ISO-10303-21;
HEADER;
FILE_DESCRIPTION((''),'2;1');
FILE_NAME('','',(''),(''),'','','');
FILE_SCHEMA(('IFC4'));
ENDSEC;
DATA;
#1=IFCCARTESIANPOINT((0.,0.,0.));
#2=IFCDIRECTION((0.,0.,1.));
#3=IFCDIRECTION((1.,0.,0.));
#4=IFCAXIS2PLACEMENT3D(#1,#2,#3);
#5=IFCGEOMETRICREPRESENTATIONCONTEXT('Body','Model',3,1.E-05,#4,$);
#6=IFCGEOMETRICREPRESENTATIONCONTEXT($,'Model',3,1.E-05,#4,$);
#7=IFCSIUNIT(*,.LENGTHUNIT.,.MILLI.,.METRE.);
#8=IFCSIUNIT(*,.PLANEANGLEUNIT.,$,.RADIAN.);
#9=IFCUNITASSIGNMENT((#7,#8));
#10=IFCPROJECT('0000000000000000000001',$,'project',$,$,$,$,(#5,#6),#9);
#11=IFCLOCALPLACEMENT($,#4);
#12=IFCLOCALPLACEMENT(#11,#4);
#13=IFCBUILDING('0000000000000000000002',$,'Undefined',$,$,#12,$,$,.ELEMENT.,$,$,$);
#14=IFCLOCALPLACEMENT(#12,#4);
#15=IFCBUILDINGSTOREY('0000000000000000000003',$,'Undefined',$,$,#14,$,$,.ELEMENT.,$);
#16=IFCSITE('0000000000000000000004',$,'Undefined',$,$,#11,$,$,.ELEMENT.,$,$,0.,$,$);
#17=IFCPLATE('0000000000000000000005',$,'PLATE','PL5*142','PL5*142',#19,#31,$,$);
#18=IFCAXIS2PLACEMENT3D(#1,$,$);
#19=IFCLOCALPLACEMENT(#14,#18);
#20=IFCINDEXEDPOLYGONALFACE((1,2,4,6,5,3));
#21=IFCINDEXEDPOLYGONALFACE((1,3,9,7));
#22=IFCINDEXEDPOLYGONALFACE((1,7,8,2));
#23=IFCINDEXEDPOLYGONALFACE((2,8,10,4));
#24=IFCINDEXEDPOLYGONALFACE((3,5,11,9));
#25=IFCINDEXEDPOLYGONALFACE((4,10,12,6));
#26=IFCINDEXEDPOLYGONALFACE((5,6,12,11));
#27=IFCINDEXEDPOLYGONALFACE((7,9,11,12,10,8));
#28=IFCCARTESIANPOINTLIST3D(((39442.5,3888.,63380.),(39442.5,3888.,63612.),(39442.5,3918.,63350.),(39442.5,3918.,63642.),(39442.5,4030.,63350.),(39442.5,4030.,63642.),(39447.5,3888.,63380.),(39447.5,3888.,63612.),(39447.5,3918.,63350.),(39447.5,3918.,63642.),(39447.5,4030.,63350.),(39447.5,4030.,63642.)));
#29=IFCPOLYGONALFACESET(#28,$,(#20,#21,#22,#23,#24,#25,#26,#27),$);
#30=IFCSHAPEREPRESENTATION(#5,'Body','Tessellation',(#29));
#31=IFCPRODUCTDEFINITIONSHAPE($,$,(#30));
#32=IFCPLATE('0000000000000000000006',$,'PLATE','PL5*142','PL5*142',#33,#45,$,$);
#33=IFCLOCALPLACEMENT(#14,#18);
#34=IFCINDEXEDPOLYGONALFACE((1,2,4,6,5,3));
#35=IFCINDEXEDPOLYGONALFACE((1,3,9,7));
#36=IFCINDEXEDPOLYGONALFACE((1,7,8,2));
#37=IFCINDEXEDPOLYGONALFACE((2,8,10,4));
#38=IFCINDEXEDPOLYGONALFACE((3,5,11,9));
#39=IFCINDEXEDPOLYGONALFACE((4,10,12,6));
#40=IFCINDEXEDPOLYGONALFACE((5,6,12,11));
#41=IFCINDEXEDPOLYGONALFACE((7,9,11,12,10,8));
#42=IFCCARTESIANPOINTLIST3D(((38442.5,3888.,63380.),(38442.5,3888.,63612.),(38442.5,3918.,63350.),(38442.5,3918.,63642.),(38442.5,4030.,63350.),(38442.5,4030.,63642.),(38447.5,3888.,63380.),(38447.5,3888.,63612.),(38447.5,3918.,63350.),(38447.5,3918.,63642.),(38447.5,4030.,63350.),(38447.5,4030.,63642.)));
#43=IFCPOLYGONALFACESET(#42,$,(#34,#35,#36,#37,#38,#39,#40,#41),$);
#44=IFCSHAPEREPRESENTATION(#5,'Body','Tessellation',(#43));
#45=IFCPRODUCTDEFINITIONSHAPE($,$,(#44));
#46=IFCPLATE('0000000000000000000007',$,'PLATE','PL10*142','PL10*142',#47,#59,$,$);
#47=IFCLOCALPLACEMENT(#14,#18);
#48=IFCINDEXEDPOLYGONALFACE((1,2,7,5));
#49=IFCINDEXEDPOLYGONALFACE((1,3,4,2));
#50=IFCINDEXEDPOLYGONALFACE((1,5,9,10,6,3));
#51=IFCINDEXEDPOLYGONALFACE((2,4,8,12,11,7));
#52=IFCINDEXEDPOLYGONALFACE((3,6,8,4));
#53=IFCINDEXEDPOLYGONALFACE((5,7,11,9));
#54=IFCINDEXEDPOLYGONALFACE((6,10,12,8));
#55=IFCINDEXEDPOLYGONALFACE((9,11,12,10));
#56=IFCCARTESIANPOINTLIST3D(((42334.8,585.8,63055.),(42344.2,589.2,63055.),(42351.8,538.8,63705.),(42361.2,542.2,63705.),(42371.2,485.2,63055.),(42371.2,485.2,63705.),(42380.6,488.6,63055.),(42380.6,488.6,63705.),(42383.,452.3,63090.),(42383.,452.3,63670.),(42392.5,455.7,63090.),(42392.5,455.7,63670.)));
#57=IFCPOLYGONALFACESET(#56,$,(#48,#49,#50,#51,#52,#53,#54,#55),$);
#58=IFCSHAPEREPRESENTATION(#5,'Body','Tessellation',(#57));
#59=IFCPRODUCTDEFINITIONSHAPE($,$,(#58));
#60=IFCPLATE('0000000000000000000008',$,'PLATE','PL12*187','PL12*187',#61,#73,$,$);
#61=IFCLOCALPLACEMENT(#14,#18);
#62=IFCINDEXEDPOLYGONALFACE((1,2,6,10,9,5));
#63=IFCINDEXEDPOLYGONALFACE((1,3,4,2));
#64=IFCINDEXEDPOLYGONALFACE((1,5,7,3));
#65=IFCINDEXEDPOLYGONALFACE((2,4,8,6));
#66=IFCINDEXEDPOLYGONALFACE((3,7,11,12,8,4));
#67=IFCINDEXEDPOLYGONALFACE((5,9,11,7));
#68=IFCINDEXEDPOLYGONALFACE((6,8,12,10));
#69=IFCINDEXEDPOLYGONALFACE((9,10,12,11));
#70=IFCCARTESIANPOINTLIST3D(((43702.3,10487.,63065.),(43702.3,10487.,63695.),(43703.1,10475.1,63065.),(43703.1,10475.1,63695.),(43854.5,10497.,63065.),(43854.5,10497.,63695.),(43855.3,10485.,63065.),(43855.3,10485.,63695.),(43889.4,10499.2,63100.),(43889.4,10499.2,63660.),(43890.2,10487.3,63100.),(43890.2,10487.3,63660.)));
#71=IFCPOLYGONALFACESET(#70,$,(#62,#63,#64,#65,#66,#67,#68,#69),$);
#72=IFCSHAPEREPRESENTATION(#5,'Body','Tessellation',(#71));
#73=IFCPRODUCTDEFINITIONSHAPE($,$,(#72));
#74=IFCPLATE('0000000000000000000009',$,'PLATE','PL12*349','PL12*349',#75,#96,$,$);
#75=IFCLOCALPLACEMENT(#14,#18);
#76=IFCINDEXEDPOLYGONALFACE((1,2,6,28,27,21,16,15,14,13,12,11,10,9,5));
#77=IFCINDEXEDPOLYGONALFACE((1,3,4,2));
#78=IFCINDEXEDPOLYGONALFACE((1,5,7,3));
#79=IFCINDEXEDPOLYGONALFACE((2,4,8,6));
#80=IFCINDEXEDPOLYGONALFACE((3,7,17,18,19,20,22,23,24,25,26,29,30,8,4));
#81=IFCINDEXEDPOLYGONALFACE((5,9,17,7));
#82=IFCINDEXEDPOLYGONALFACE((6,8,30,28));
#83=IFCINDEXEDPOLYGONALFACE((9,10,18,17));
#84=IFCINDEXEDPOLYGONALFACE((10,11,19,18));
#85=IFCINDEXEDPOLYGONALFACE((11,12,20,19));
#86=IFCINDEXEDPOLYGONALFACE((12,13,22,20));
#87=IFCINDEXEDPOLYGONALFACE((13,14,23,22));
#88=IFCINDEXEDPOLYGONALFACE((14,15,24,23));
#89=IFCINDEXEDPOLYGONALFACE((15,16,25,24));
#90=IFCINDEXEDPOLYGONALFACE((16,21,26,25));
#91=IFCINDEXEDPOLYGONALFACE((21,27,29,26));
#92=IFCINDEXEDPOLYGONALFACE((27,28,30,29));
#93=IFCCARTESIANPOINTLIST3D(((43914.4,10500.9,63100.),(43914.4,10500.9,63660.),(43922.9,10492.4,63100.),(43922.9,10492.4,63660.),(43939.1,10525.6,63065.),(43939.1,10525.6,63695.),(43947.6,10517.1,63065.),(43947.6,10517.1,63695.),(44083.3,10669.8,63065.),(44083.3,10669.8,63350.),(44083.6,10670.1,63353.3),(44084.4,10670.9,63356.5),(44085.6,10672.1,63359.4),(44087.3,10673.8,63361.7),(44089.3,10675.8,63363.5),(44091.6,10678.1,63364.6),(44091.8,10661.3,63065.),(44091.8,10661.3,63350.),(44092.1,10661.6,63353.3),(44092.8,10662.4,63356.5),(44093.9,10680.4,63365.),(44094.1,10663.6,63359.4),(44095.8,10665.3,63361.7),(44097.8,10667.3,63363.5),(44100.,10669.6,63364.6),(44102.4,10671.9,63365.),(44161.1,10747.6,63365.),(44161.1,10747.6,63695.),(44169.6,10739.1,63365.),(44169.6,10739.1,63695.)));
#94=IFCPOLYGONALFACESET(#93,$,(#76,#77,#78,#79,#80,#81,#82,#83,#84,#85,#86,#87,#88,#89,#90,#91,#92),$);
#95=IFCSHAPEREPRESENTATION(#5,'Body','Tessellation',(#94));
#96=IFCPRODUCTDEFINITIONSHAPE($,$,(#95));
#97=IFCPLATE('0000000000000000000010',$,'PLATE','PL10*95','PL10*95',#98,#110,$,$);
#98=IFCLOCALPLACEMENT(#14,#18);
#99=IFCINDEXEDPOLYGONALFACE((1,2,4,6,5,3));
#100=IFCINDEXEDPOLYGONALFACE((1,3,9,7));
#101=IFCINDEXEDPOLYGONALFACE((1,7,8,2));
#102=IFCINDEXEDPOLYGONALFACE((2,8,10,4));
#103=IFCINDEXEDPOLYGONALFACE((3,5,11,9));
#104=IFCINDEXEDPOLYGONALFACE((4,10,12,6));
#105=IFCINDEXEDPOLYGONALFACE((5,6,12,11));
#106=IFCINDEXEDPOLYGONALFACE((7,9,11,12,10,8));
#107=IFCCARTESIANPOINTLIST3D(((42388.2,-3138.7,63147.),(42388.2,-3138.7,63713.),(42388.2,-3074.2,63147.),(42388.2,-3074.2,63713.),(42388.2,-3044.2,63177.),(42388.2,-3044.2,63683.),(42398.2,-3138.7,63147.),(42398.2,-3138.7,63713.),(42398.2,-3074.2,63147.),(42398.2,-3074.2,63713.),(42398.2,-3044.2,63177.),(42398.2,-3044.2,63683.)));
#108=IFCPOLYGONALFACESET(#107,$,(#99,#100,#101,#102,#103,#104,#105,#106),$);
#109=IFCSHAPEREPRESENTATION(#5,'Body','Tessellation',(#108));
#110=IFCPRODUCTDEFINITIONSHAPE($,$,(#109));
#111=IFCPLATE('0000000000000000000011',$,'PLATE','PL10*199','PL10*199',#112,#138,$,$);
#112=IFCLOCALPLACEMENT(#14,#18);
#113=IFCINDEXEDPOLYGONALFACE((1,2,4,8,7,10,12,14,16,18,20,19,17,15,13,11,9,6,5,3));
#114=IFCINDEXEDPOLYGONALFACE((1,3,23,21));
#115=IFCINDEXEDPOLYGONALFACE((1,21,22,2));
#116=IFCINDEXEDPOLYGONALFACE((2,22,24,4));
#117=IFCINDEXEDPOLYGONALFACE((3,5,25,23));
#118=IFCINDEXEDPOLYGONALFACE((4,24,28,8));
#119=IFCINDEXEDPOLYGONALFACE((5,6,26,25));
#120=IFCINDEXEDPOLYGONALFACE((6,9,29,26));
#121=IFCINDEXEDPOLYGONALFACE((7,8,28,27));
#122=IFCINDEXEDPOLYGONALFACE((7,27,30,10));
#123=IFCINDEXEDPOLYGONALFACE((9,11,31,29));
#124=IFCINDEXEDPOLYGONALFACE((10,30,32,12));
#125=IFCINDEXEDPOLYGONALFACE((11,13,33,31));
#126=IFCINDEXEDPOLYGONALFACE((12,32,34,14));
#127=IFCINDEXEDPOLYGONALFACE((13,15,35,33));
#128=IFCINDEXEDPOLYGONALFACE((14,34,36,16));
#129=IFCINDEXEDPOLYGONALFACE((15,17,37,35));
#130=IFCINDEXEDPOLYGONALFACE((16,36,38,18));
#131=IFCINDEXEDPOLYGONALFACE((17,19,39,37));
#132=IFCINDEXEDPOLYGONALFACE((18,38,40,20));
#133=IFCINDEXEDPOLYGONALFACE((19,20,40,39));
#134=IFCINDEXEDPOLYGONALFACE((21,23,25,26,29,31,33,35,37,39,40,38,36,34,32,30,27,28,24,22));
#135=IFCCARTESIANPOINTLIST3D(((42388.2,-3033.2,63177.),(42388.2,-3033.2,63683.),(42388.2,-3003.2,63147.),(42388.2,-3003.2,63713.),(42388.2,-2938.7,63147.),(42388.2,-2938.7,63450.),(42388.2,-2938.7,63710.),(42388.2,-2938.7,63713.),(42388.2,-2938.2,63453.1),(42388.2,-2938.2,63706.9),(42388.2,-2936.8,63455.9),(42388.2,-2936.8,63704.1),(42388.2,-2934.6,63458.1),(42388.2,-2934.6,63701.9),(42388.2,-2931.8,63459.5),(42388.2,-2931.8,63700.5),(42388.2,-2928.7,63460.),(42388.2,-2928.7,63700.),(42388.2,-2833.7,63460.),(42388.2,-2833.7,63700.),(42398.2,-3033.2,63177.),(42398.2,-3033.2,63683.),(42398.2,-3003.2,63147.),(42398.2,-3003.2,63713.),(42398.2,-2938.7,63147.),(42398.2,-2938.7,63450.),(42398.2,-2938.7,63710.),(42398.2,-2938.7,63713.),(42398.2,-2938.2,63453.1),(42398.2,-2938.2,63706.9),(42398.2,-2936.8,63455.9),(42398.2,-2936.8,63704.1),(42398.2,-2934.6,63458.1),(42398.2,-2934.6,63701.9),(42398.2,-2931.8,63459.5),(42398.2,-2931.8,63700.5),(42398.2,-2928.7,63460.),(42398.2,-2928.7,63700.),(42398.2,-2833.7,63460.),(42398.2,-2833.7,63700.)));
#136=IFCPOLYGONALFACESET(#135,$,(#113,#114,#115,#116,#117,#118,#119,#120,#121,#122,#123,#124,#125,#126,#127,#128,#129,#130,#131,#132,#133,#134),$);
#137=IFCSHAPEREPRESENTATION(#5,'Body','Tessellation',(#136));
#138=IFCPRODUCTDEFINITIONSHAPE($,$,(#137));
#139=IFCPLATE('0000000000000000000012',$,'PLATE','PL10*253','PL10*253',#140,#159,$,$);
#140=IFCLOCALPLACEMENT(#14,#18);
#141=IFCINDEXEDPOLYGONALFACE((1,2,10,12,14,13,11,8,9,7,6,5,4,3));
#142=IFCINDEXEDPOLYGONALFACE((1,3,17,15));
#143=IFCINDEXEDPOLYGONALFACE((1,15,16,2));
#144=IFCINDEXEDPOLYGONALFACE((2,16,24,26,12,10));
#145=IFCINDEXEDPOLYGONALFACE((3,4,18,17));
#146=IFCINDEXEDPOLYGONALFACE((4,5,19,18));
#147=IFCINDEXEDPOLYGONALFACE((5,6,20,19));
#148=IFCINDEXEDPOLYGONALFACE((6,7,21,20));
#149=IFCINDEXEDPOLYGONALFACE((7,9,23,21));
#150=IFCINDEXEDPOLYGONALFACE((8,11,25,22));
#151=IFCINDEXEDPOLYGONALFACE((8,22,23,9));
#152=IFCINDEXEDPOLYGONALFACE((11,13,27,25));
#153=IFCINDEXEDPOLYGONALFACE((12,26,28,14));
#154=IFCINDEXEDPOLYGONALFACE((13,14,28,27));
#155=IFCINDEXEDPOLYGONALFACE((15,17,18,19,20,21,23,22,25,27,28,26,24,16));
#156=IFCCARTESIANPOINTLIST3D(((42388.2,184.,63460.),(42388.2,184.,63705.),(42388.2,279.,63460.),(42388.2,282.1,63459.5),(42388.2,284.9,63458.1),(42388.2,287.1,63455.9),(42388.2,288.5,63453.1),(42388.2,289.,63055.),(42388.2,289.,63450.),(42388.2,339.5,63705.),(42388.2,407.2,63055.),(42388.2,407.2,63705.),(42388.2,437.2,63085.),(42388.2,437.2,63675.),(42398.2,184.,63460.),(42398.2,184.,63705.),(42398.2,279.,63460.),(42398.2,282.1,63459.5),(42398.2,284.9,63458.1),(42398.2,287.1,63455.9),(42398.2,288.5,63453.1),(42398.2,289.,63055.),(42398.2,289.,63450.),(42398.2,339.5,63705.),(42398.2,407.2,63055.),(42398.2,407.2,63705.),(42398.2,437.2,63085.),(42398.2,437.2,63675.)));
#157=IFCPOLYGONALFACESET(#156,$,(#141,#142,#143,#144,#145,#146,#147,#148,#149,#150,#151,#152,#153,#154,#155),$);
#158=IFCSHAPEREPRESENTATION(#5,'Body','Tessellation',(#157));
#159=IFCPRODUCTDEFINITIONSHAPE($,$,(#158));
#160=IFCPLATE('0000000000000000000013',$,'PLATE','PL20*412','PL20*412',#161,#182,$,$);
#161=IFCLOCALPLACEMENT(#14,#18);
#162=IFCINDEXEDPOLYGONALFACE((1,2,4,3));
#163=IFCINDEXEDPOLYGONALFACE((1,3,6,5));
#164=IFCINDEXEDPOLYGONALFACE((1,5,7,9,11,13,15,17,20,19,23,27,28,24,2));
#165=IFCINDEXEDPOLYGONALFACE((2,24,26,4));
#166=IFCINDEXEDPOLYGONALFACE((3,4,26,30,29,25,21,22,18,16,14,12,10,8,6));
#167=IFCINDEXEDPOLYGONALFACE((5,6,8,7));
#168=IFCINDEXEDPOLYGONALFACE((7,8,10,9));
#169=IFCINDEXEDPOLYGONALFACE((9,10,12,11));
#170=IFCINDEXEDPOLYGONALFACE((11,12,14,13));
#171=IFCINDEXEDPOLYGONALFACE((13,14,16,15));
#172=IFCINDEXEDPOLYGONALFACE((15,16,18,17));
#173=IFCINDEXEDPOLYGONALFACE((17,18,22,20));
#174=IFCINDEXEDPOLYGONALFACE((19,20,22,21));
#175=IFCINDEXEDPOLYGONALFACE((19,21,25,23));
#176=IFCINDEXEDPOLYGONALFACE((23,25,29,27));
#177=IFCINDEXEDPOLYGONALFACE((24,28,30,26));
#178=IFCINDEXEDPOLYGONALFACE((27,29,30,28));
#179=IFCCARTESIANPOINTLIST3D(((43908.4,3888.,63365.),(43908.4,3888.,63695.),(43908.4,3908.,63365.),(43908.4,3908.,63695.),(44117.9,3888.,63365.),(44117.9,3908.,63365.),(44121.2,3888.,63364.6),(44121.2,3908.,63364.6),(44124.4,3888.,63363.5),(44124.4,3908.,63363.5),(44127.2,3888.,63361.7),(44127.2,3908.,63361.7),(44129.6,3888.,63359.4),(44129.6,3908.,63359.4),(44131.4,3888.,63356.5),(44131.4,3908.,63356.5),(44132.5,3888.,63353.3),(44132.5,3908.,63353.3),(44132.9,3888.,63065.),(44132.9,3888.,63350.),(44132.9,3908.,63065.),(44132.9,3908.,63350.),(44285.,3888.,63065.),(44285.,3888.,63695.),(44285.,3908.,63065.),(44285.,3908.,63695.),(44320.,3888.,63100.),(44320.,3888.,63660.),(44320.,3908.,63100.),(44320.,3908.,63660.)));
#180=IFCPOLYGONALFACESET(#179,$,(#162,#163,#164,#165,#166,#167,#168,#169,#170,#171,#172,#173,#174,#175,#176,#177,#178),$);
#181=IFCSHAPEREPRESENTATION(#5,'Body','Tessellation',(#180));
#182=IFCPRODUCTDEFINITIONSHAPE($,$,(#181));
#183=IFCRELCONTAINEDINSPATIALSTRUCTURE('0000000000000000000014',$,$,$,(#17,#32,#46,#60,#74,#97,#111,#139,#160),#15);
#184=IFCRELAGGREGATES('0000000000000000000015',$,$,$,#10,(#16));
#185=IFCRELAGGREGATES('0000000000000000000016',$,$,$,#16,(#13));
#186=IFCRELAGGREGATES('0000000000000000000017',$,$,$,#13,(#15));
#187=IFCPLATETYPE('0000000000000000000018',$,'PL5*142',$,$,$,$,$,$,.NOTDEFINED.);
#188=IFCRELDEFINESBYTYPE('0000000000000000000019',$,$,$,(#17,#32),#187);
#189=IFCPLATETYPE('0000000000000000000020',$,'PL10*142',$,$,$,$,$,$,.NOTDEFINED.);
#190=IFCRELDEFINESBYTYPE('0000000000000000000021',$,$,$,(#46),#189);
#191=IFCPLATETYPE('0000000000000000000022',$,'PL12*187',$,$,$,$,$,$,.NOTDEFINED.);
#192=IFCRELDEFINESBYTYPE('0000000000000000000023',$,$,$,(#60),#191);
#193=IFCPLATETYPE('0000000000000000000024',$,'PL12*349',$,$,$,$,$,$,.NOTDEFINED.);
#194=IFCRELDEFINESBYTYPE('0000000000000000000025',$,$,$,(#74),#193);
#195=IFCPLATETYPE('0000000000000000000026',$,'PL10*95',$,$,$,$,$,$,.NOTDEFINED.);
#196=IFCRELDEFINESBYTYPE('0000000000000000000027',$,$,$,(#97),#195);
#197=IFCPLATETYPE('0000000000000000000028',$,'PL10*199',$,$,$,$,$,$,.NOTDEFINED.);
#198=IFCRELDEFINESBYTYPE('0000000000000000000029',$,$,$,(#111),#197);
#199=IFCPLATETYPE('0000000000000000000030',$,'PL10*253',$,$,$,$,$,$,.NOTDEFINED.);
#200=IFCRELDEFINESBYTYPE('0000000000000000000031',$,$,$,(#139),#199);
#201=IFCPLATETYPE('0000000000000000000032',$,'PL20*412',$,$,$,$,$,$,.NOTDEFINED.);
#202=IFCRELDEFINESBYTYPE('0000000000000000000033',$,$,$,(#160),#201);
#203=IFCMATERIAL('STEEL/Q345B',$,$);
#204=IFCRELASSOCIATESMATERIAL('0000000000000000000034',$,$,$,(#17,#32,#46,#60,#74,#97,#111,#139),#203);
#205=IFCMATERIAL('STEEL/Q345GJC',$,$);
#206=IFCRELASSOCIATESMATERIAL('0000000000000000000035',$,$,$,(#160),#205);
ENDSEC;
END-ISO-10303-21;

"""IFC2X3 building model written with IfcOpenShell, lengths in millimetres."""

from ifc_helpers import new_model, si_unit, frame, origin_with_axes, place, context, project, spatial, polyline, outline, extrude, material, type_object, element, save


model = new_model("IFC2X3")

# Units and contexts
model_context_1 = context("Model", 3, precision=1e-05, world=origin_with_axes(), identifier="Body")
model_context_2 = context("Model", 3, precision=1e-05, world=origin_with_axes())
ifc_project = project(units=[si_unit("LENGTHUNIT", "METRE", prefix="MILLI"), si_unit("PLANEANGLEUNIT", "RADIAN")], contexts=[model_context_1, model_context_2])

# Site, building, storey
site_placement = place(None, origin_with_axes())
site = spatial("IfcSite", under=ifc_project, at=site_placement, Name="Undefined", CompositionType="ELEMENT", RefElevation=0.0)
building_placement = place(site_placement, origin_with_axes())
building = spatial("IfcBuilding", under=site, at=building_placement, Name="Undefined", CompositionType="ELEMENT")
storey_placement = place(building_placement, origin_with_axes())
storey = spatial("IfcBuildingStorey", under=building, at=storey_placement, Name="Undefined", CompositionType="ELEMENT")

# Shared definitions
ifc_material_1 = material(Name="STEEL/Q345B")
ifc_material_2 = material(Name="STEEL/Q345GJC")

# Plates
plate_type_1 = type_object("IfcPlateType", Name="PL5*142", PredefinedType="NOTDEFINED")
for number, where, z_axis, x_axis, name in (
    (1, (39445.0, 4030.0, 63642.0), (1.0, 0.0, 0.0), (0.0, -1.0, 0.0), "PLATE"),
    (2, (38445.0, 4030.0, 63642.0), (1.0, 0.0, 0.0), (0.0, -1.0, 0.0), "PLATE"),
):
    element("IfcPlate", number, at=place(storey_placement, frame(where, z_axis=z_axis, x_axis=x_axis)), inside=storey, type_object=plate_type_1, material=ifc_material_1, Name=name, Description="PL5*142", ObjectType="PL5*142", context=model_context_1, shape_type="SweptSolid", body=[
        extrude(outline(polyline([(0.0, 0.0), (112.0, 0.0), (142.0, 30.0), (142.0, 262.0), (112.0, 292.0), (0.0, 292.0), (0.0, 0.0)])), frame((0.0, 0.0, -2.5), z_axis=(0.0, 0.0, 1.0), x_axis=(1.0, 0.0, 0.0)), (0.0, 0.0, 1.0), 5.0),
    ])
plate_type_2 = type_object("IfcPlateType", Name="PL10*142", PredefinedType="NOTDEFINED")
plate_1_placement = place(storey_placement, frame((42387.8, 454.0, 63705.0), z_axis=(-0.940467, -0.339884, 0.0), x_axis=(-0.339884, 0.940467, 0.0)))
element("IfcPlate", 3, at=plate_1_placement, inside=storey, type_object=plate_type_2, material=ifc_material_1, Name="PLATE", Description="PL10*142", ObjectType="PL10*142", context=model_context_1, shape_type="SweptSolid", body=[
    extrude(outline(polyline([(0.0, 35.0), (35.0, 0.0), (92.0, 0.0), (142.0, 650.0), (35.0, 650.0), (0.0, 615.0), (0.0, 35.0)])), frame((0.0, 0.0, -5.0), z_axis=(0.0, 0.0, 1.0), x_axis=(1.0, 0.0, 0.0)), (0.0, 0.0, 1.0), 10.0),
])
plate_type_3 = type_object("IfcPlateType", Name="PL12*187", PredefinedType="NOTDEFINED")
plate_2_placement = place(storey_placement, frame((43889.8, 10493.3, 63065.0), z_axis=(-0.065184, 0.997873, 0.0), x_axis=(-0.997873, -0.065183, 0.0)))
element("IfcPlate", 4, at=plate_2_placement, inside=storey, type_object=plate_type_3, material=ifc_material_1, Name="PLATE", Description="PL12*187", ObjectType="PL12*187", context=model_context_1, shape_type="SweptSolid", body=[
    extrude(outline(polyline([(0.0, 35.0), (35.0, 0.0), (187.5, 0.0), (187.5, 630.0), (35.0, 630.0), (0.0, 595.0), (0.0, 35.0)])), frame((0.0, 0.0, -6.0), z_axis=(0.0, 0.0, 1.0), x_axis=(1.0, 0.0, 0.0)), (0.0, 0.0, 1.0), 12.0),
])
plate_type_4 = type_object("IfcPlateType", Name="PL12*349", PredefinedType="NOTDEFINED")
plate_3_placement = place(storey_placement, frame((44165.4, 10743.4, 63695.0), z_axis=(-0.707107, 0.707107, 0.0), x_axis=(0.0, 0.0, -1.0)))
element("IfcPlate", 5, at=plate_3_placement, inside=storey, type_object=plate_type_4, material=ifc_material_1, Name="PLATE", Description="PL12*349", ObjectType="PL12*349", context=model_context_1, shape_type="SweptSolid", body=[
    extrude(outline(polyline([(0.0, 0.0), (330.0, 0.0), (330.0, 95.0), (330.4, 98.4), (331.5, 101.5), (333.3, 104.4), (335.6, 106.8), (338.5, 108.5), (341.7, 109.7), (345.0, 110.0), (630.0, 110.0), (630.0, 313.9), (595.0, 348.9), (35.0, 348.9), (0.0, 313.9), (0.0, 0.0)])), frame((0.0, 0.0, -6.0), z_axis=(0.0, 0.0, 1.0), x_axis=(1.0, 0.0, 0.0)), (0.0, 0.0, 1.0), 12.0),
])
plate_type_5 = type_object("IfcPlateType", Name="PL10*95", PredefinedType="NOTDEFINED")
plate_4_placement = place(storey_placement, frame((42393.2, -3044.2, 63147.0), z_axis=(-1.0, 0.0, 0.0), x_axis=(0.0, -1.0, 0.0)))
element("IfcPlate", 6, at=plate_4_placement, inside=storey, type_object=plate_type_5, material=ifc_material_1, Name="PLATE", Description="PL10*95", ObjectType="PL10*95", context=model_context_1, shape_type="SweptSolid", body=[
    extrude(outline(polyline([(0.0, 30.0), (30.0, 0.0), (94.5, 0.0), (94.5, 566.0), (30.0, 566.0), (0.0, 536.0), (0.0, 30.0)])), frame((0.0, 0.0, -5.0), z_axis=(0.0, 0.0, 1.0), x_axis=(1.0, 0.0, 0.0)), (0.0, 0.0, 1.0), 10.0),
])
plate_type_6 = type_object("IfcPlateType", Name="PL10*199", PredefinedType="NOTDEFINED")
plate_5_placement = place(storey_placement, frame((42393.2, -3033.2, 63177.0), z_axis=(1.0, 0.0, 0.0), x_axis=(0.0, 0.707107, -0.707107)))
element("IfcPlate", 7, at=plate_5_placement, inside=storey, type_object=plate_type_6, material=ifc_material_1, Name="PLATE", Description="PL10*199", ObjectType="PL10*199", context=model_context_1, shape_type="SweptSolid", body=[
    extrude(outline(polyline([(0.0, 0.0), (42.4, 0.0), (88.0, 45.6), (-126.2, 259.9), (-128.1, 262.4), (-129.0, 265.4), (-129.0, 268.5), (-128.1, 271.5), (-126.2, 274.0), (-59.0, 341.2), (-228.7, 510.9), (-295.9, 443.7), (-298.5, 441.9), (-301.4, 440.9), (-304.6, 440.9), (-307.5, 441.9), (-310.1, 443.7), (-312.2, 445.8), (-357.8, 400.2), (-357.8, 357.8), (0.0, 0.0)])), frame((0.0, 0.0, -5.0), z_axis=(0.0, 0.0, 1.0), x_axis=(1.0, 0.0, 0.0)), (0.0, 0.0, 1.0), 10.0),
])
plate_type_7 = type_object("IfcPlateType", Name="PL10*253", PredefinedType="NOTDEFINED")
plate_6_placement = place(storey_placement, frame((42393.2, 437.2, 63085.0), z_axis=(-1.0, 0.0, 0.0), x_axis=(0.0, -0.707107, -0.707107)))
element("IfcPlate", 8, at=plate_6_placement, inside=storey, type_object=plate_type_7, material=ifc_material_1, Name="PLATE", Description="PL10*253", ObjectType="PL10*253", context=model_context_1, shape_type="SweptSolid", body=[
    extrude(outline(polyline([(0.0, 0.0), (42.4, 0.0), (126.0, 83.6), (-153.3, 362.9), (-155.1, 365.4), (-156.1, 368.4), (-156.1, 371.5), (-155.1, 374.5), (-153.3, 377.0), (-86.1, 444.2), (-259.4, 617.5), (-369.3, 507.5), (-417.2, 459.6), (-417.2, 417.2), (0.0, 0.0)])), frame((0.0, 0.0, -5.0), z_axis=(0.0, 0.0, 1.0), x_axis=(1.0, 0.0, 0.0)), (0.0, 0.0, 1.0), 10.0),
])
plate_type_8 = type_object("IfcPlateType", Name="PL20*412", PredefinedType="NOTDEFINED")
plate_7_placement = place(storey_placement, frame((44320.0, 3898.0, 63695.0), z_axis=(0.0, -1.0, 0.0), x_axis=(-1.0, 0.0, 0.0)))
element("IfcPlate", 9, at=plate_7_placement, inside=storey, type_object=plate_type_8, material=ifc_material_2, Name="PLATE", Description="PL20*412", ObjectType="PL20*412", context=model_context_1, shape_type="SweptSolid", body=[
    extrude(outline(polyline([(0.0, 35.0), (35.0, 0.0), (411.6, 0.0), (411.6, 330.0), (202.1, 330.0), (198.8, 330.4), (195.6, 331.5), (192.8, 333.3), (190.4, 335.6), (188.6, 338.5), (187.5, 341.7), (187.1, 345.0), (187.1, 630.0), (35.0, 630.0), (0.0, 595.0), (0.0, 35.0)])), frame((0.0, 0.0, -10.0), z_axis=(0.0, 0.0, 1.0), x_axis=(1.0, 0.0, 0.0)), (0.0, 0.0, 1.0), 20.0),
])

save(model, "model.ifc")
